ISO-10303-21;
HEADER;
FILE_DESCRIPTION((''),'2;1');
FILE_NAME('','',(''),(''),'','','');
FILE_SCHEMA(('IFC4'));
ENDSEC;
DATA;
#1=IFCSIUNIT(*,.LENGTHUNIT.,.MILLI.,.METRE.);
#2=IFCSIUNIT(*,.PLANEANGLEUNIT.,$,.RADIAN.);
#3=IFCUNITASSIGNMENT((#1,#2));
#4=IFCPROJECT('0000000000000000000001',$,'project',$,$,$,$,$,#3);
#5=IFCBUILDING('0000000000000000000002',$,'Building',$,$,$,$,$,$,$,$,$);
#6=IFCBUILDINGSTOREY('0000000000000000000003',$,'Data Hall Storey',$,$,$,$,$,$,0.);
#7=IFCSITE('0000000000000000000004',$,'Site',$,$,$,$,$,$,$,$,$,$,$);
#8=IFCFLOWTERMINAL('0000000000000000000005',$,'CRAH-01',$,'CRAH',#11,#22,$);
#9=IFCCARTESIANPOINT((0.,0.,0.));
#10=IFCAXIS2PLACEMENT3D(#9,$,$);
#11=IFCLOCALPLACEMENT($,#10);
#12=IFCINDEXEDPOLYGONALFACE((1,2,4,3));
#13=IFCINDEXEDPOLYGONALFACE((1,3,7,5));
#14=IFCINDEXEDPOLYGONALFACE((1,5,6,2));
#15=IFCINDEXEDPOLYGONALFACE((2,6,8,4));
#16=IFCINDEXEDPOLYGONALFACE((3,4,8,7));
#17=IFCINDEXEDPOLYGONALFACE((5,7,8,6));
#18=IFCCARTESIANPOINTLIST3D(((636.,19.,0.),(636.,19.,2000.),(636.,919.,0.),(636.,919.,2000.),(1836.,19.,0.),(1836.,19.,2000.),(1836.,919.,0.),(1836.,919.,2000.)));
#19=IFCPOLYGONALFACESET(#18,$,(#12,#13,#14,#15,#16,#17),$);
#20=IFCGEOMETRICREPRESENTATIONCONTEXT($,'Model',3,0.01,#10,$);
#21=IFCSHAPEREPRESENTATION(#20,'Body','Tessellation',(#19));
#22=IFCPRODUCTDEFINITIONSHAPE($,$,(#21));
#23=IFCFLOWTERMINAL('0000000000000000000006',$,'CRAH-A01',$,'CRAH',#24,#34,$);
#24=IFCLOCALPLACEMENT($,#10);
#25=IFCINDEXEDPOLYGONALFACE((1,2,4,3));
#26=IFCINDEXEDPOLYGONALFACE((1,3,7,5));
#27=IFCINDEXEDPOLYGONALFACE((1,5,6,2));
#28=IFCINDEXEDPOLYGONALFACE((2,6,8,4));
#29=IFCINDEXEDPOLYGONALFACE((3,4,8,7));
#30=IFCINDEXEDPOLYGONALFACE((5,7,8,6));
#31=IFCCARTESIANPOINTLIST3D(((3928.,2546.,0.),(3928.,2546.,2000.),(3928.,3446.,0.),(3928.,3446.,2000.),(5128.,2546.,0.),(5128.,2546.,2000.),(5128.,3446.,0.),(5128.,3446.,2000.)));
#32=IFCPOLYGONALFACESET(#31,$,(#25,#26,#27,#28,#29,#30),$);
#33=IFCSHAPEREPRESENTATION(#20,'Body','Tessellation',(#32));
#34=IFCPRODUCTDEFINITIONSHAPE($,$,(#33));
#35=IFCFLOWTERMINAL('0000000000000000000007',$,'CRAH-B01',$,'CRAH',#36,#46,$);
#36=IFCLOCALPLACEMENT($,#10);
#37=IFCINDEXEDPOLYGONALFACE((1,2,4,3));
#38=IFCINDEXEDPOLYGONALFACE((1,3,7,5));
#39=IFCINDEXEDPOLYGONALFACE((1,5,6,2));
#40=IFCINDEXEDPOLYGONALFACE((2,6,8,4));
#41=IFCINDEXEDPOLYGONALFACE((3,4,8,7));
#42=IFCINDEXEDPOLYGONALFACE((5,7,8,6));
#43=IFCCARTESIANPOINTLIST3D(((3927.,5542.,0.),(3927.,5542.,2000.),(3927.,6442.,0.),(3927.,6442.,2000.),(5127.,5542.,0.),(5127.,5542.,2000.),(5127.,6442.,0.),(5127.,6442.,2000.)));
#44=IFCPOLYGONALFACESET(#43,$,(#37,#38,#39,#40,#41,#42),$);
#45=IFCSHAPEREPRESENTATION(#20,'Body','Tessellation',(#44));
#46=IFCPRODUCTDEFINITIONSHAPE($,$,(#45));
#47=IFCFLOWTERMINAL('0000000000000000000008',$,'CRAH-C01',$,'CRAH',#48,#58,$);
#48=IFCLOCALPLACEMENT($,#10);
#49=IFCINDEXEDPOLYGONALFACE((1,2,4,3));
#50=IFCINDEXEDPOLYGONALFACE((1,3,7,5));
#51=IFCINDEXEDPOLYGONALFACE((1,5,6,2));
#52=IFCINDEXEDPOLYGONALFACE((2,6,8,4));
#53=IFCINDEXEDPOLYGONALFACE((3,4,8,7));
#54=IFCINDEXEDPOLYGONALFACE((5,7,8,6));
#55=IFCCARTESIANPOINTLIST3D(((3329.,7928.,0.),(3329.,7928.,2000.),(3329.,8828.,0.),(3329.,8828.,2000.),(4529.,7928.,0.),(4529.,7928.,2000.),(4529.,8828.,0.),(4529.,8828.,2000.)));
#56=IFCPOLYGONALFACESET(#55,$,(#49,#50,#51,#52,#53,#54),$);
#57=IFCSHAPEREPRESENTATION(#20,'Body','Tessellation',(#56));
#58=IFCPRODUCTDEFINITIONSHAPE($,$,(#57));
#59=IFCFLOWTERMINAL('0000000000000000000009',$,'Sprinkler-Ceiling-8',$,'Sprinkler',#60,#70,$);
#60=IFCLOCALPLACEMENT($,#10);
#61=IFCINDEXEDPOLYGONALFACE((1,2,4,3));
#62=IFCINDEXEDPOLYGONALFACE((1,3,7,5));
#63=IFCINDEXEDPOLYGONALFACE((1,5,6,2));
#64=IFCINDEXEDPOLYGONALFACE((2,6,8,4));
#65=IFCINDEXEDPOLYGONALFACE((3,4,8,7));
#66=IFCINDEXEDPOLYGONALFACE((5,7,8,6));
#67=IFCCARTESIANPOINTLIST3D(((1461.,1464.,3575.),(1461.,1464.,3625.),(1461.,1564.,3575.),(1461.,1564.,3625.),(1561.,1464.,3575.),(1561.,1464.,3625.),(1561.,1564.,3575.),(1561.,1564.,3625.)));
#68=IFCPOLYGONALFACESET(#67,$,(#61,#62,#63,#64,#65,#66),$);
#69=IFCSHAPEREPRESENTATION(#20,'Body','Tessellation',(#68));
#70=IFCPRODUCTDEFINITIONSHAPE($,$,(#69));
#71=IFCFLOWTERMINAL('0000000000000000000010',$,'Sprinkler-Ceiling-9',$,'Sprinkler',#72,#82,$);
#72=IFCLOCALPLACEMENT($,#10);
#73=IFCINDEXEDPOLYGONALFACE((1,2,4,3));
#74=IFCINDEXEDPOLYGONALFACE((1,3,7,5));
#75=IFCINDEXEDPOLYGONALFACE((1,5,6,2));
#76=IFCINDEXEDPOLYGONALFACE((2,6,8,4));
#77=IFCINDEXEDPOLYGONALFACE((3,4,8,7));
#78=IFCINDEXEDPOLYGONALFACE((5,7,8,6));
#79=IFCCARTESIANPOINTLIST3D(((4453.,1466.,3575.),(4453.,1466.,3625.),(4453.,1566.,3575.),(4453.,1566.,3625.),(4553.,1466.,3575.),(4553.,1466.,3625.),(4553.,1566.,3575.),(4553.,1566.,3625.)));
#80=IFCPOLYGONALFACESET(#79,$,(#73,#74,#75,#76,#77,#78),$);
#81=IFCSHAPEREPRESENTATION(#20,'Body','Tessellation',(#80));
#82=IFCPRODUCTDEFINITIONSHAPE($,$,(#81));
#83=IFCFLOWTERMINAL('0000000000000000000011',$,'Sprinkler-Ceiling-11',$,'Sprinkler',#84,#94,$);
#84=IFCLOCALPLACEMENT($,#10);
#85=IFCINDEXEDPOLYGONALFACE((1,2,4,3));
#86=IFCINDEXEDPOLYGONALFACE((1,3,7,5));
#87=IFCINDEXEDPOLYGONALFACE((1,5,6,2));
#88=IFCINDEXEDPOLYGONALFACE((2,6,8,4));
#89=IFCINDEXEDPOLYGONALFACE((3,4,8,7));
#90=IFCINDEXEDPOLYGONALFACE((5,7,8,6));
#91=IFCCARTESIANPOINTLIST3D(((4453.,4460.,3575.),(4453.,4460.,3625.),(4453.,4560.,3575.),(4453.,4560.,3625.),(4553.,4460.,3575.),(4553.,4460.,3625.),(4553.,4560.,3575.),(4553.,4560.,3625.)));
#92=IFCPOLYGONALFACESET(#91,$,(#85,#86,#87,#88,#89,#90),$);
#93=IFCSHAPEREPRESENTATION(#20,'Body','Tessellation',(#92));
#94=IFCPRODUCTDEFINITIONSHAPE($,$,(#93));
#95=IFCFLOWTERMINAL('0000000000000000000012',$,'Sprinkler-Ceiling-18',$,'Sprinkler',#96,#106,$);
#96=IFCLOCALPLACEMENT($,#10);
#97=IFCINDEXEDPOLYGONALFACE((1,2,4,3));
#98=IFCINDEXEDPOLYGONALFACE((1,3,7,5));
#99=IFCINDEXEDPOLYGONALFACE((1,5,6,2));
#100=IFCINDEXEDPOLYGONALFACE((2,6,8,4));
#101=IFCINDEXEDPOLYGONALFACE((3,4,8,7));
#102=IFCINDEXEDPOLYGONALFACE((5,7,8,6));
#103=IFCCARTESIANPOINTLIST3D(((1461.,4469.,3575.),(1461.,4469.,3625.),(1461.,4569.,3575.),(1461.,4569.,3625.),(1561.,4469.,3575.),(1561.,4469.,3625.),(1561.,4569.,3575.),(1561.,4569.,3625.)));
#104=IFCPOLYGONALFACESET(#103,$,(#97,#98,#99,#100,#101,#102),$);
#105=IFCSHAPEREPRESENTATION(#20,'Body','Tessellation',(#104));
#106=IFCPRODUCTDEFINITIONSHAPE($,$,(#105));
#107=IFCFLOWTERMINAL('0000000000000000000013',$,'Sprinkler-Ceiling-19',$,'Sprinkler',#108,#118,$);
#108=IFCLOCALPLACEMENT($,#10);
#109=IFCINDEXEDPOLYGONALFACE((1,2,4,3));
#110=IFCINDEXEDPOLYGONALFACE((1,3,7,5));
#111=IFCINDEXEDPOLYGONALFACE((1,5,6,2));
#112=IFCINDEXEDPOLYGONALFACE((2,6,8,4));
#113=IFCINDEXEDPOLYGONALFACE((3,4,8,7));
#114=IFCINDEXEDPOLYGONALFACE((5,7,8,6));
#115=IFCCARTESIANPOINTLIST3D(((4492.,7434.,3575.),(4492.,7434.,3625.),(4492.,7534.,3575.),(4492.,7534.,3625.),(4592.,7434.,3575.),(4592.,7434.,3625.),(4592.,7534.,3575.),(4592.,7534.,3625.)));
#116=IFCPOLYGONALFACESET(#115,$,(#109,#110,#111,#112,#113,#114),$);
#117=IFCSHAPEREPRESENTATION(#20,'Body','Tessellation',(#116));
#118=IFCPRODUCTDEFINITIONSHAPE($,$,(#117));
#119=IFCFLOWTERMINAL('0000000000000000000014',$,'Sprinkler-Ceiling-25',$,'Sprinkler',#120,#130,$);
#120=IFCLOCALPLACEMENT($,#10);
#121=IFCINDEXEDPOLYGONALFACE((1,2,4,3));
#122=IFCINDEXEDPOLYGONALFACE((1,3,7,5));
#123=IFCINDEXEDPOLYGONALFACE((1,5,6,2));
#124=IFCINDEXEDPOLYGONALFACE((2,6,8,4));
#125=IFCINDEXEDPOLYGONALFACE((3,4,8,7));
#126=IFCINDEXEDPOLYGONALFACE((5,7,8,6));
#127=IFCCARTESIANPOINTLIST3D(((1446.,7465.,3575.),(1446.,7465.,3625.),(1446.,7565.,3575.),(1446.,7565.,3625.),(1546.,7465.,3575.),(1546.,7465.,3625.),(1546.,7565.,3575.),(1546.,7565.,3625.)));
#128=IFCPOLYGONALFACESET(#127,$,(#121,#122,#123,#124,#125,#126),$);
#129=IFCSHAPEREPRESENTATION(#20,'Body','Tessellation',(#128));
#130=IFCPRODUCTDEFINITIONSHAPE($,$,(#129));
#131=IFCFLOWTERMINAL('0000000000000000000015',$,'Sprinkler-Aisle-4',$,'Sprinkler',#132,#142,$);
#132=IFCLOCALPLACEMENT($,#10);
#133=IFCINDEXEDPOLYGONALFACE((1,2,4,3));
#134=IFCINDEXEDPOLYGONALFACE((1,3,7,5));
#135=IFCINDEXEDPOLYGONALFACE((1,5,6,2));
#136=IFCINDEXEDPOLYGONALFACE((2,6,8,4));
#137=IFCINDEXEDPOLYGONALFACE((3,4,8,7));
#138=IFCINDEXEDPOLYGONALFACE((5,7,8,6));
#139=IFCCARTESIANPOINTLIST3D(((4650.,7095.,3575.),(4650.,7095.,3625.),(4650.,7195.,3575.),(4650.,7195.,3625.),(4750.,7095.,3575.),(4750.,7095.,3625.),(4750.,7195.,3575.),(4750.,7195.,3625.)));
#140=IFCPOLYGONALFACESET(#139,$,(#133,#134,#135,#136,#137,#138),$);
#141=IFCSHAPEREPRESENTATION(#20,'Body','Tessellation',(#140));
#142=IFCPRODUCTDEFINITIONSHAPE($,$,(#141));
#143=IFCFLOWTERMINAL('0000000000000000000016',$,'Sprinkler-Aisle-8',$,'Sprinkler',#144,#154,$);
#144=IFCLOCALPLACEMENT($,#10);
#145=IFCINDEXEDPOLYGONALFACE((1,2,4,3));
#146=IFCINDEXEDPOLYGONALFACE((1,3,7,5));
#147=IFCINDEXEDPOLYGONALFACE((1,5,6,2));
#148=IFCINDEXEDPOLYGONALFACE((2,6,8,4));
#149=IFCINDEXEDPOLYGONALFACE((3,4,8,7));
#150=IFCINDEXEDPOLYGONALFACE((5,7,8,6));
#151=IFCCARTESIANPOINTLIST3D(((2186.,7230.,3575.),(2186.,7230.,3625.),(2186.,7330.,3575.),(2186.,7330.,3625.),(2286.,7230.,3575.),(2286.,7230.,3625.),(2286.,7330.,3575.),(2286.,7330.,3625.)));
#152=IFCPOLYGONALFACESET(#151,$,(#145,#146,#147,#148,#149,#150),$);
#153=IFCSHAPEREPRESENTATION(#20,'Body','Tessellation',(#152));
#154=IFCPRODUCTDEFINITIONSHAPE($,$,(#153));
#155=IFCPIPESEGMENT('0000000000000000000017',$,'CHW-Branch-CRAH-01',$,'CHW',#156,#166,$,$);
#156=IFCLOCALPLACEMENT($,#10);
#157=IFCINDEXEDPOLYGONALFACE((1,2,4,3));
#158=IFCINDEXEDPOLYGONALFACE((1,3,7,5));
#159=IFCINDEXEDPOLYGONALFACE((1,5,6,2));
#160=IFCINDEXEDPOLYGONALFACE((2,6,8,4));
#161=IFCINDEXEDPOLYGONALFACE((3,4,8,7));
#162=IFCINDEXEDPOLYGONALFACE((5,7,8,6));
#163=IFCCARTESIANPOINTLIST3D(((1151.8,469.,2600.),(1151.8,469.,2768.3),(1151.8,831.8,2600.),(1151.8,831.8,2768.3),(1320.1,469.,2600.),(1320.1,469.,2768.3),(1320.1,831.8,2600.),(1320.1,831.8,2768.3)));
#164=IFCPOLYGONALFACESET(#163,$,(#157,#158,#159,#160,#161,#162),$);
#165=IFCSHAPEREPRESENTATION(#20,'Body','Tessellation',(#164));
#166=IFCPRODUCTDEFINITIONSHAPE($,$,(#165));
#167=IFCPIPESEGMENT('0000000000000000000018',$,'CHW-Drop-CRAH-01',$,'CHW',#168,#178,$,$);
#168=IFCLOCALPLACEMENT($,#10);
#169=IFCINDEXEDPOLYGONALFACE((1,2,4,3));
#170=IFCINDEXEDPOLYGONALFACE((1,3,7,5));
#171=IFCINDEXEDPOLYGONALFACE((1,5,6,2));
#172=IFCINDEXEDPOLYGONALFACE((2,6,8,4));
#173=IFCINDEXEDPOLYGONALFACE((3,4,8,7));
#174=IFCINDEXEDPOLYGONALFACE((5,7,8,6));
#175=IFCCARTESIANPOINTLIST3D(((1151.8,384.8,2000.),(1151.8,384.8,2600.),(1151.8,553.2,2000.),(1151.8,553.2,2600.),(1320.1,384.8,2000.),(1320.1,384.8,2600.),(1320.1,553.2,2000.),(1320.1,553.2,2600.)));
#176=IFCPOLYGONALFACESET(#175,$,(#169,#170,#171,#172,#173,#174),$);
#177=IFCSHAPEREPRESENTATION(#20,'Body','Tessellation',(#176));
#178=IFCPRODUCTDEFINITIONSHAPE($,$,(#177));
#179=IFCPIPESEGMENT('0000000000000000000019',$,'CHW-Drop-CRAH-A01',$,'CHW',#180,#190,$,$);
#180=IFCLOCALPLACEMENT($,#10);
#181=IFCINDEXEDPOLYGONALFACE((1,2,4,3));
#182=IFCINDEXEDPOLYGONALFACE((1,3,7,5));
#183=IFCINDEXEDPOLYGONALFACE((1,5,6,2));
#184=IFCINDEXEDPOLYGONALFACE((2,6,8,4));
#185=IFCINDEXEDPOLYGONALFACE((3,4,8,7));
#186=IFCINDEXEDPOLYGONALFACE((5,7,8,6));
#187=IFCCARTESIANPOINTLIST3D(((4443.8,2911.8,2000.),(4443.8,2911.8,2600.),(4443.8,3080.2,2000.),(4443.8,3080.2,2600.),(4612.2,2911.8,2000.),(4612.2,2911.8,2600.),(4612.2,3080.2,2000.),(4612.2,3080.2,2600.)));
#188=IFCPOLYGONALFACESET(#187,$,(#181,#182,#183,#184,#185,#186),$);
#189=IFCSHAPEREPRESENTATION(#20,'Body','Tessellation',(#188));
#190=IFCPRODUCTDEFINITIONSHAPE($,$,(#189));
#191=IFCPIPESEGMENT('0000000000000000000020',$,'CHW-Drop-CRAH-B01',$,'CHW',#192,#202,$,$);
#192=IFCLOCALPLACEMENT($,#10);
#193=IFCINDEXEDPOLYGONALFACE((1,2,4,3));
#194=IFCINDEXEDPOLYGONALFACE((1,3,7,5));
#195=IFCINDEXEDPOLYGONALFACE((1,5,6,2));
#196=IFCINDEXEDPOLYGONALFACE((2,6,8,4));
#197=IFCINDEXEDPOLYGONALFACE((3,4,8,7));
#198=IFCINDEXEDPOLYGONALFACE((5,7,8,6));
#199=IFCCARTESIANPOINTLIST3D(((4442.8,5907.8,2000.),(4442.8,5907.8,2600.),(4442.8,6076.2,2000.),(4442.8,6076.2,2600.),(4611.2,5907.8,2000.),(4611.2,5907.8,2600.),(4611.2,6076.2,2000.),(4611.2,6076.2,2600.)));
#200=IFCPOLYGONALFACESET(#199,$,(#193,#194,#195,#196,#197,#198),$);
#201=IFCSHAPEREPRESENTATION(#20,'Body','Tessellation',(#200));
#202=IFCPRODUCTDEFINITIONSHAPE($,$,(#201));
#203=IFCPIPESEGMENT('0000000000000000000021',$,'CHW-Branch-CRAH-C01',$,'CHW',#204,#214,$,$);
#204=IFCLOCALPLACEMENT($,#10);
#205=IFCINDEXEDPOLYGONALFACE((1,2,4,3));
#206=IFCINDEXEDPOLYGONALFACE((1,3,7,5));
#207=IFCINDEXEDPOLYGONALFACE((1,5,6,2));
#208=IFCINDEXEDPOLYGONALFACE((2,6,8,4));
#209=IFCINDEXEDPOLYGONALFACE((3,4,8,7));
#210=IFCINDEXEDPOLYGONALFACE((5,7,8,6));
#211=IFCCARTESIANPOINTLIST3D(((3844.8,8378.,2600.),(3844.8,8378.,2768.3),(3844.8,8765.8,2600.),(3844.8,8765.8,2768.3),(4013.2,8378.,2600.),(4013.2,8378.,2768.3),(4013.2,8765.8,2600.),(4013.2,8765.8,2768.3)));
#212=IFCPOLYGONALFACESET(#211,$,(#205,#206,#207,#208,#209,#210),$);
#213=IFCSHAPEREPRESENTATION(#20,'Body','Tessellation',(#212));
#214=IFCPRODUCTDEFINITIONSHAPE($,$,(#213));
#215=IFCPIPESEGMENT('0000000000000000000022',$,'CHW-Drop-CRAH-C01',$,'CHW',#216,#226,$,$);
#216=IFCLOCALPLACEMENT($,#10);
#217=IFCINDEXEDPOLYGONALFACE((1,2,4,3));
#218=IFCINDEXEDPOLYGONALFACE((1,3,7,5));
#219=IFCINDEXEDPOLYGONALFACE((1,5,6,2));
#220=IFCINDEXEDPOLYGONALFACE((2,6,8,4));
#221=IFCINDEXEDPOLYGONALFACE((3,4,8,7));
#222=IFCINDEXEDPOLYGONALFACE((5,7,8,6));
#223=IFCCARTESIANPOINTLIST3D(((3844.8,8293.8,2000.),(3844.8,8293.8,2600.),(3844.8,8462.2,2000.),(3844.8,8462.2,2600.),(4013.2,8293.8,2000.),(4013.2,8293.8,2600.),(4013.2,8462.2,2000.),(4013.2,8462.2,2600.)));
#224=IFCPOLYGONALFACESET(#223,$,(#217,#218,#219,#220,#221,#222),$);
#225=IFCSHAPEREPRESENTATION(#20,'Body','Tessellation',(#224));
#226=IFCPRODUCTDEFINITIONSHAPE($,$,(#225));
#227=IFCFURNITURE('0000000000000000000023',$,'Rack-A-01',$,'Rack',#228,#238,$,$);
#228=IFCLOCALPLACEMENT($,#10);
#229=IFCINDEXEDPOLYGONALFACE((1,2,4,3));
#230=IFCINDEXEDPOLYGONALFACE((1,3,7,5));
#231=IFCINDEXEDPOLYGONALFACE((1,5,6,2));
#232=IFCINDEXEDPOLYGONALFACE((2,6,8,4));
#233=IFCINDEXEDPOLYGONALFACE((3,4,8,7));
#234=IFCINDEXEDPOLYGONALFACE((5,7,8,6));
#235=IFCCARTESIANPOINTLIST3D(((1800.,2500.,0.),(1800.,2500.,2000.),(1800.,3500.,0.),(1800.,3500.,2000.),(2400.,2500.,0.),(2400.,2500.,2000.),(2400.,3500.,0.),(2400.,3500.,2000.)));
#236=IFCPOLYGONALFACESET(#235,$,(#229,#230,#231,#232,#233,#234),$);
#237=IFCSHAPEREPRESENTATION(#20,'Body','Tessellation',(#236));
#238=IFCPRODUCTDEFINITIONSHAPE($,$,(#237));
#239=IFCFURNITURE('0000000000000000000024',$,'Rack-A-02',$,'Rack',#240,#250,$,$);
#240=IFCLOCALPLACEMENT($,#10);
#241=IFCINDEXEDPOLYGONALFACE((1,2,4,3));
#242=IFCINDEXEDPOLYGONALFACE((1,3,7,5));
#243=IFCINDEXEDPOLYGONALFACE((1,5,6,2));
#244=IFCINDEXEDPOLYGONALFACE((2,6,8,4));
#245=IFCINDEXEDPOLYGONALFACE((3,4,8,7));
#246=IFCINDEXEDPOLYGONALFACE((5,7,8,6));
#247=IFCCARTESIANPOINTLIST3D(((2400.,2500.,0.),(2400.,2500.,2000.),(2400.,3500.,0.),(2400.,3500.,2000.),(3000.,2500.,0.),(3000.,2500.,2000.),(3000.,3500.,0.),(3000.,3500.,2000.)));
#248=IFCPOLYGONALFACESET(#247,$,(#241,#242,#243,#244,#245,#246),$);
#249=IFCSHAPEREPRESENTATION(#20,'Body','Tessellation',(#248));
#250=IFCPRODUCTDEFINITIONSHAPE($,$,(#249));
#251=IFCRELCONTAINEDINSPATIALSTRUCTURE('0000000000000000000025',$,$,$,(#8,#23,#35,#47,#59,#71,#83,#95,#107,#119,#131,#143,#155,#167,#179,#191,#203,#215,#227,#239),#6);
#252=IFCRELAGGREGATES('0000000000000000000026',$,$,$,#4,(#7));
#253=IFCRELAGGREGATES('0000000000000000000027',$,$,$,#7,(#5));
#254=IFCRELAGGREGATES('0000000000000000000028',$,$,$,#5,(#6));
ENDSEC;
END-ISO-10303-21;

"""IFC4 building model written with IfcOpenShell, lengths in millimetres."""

from ifc_helpers import new_model, si_unit, frame, origin, place, context, project, spatial, rectangle, extrude, element, save


model = new_model("IFC4")

# Units and contexts
model_context = context("Model", 3, precision=0.01, world=origin())
ifc_project = project(units=[si_unit("LENGTHUNIT", "METRE", prefix="MILLI"), si_unit("PLANEANGLEUNIT", "RADIAN")])

# Site, building, storey
site = spatial("IfcSite", under=ifc_project, Name="Site")
building = spatial("IfcBuilding", under=site, Name="Building")
storey = spatial("IfcBuildingStorey", under=building, Name="Data Hall Storey", Elevation=0.0)

# Flow terminals
for number, where, name in (
    (1, (1236.0, 469.0, 0.0), "CRAH-01"),
    (2, (4528.0, 2996.0, 0.0), "CRAH-A01"),
    (3, (4527.0, 5992.0, 0.0), "CRAH-B01"),
    (4, (3929.0, 8378.0, 0.0), "CRAH-C01"),
):
    element("IfcFlowTerminal", number, at=place(None, frame(where)), inside=storey, Name=name, ObjectType="CRAH", context=model_context, shape_type="SweptSolid", body=[
        extrude(rectangle(XDim=1200.0, YDim=900.0), origin(), (0.0, 0.0, 1.0), 2000.0),
    ])
for number, where, name in (
    (5, (1511.0, 1514.0, 3575.0), "Sprinkler-Ceiling-8"),
    (6, (4503.0, 1516.0, 3575.0), "Sprinkler-Ceiling-9"),
    (7, (4503.0, 4510.0, 3575.0), "Sprinkler-Ceiling-11"),
    (8, (1511.0, 4519.0, 3575.0), "Sprinkler-Ceiling-18"),
    (9, (4542.0, 7484.0, 3575.0), "Sprinkler-Ceiling-19"),
    (10, (1496.0, 7515.0, 3575.0), "Sprinkler-Ceiling-25"),
    (11, (4700.0, 7145.0, 3575.0), "Sprinkler-Aisle-4"),
    (12, (2236.0, 7280.0, 3575.0), "Sprinkler-Aisle-8"),
):
    element("IfcFlowTerminal", number, at=place(None, frame(where)), inside=storey, Name=name, ObjectType="Sprinkler", context=model_context, shape_type="SweptSolid", body=[
        extrude(rectangle(XDim=100.0, YDim=100.0), origin(), (0.0, 0.0, 1.0), 50.0),
    ])

# Pipe segments
pipe_segment_1_placement = place(None, frame((1236.0, 650.4, 2600.0)))
element("IfcPipeSegment", 13, at=pipe_segment_1_placement, inside=storey, Name="CHW-Branch-CRAH-01", ObjectType="CHW", context=model_context, shape_type="SweptSolid", body=[
    extrude(rectangle(XDim=168.3, YDim=362.9), origin(), (0.0, 0.0, 1.0), 168.3),
])
for number, where, name in (
    (14, (1236.0, 469.0, 2000.0), "CHW-Drop-CRAH-01"),
    (15, (4528.0, 2996.0, 2000.0), "CHW-Drop-CRAH-A01"),
    (16, (4527.0, 5992.0, 2000.0), "CHW-Drop-CRAH-B01"),
):
    element("IfcPipeSegment", number, at=place(None, frame(where)), inside=storey, Name=name, ObjectType="CHW", context=model_context, shape_type="SweptSolid", body=[
        extrude(rectangle(XDim=168.3, YDim=168.3), origin(), (0.0, 0.0, 1.0), 600.0),
    ])
pipe_segment_2_placement = place(None, frame((3929.0, 8571.9, 2600.0)))
element("IfcPipeSegment", 17, at=pipe_segment_2_placement, inside=storey, Name="CHW-Branch-CRAH-C01", ObjectType="CHW", context=model_context, shape_type="SweptSolid", body=[
    extrude(rectangle(XDim=168.3, YDim=387.9), origin(), (0.0, 0.0, 1.0), 168.3),
])
pipe_segment_3_placement = place(None, frame((3929.0, 8378.0, 2000.0)))
element("IfcPipeSegment", 18, at=pipe_segment_3_placement, inside=storey, Name="CHW-Drop-CRAH-C01", ObjectType="CHW", context=model_context, shape_type="SweptSolid", body=[
    extrude(rectangle(XDim=168.3, YDim=168.3), origin(), (0.0, 0.0, 1.0), 600.0),
])

# Furniture
for number, where, name in (
    (19, (2100.0, 3000.0, 0.0), "Rack-A-01"),
    (20, (2700.0, 3000.0, 0.0), "Rack-A-02"),
):
    element("IfcFurniture", number, at=place(None, frame(where)), inside=storey, Name=name, ObjectType="Rack", context=model_context, shape_type="SweptSolid", body=[
        extrude(rectangle(XDim=600.0, YDim=1000.0), origin(), (0.0, 0.0, 1.0), 2000.0),
    ])

save(model, "model.ifc")
